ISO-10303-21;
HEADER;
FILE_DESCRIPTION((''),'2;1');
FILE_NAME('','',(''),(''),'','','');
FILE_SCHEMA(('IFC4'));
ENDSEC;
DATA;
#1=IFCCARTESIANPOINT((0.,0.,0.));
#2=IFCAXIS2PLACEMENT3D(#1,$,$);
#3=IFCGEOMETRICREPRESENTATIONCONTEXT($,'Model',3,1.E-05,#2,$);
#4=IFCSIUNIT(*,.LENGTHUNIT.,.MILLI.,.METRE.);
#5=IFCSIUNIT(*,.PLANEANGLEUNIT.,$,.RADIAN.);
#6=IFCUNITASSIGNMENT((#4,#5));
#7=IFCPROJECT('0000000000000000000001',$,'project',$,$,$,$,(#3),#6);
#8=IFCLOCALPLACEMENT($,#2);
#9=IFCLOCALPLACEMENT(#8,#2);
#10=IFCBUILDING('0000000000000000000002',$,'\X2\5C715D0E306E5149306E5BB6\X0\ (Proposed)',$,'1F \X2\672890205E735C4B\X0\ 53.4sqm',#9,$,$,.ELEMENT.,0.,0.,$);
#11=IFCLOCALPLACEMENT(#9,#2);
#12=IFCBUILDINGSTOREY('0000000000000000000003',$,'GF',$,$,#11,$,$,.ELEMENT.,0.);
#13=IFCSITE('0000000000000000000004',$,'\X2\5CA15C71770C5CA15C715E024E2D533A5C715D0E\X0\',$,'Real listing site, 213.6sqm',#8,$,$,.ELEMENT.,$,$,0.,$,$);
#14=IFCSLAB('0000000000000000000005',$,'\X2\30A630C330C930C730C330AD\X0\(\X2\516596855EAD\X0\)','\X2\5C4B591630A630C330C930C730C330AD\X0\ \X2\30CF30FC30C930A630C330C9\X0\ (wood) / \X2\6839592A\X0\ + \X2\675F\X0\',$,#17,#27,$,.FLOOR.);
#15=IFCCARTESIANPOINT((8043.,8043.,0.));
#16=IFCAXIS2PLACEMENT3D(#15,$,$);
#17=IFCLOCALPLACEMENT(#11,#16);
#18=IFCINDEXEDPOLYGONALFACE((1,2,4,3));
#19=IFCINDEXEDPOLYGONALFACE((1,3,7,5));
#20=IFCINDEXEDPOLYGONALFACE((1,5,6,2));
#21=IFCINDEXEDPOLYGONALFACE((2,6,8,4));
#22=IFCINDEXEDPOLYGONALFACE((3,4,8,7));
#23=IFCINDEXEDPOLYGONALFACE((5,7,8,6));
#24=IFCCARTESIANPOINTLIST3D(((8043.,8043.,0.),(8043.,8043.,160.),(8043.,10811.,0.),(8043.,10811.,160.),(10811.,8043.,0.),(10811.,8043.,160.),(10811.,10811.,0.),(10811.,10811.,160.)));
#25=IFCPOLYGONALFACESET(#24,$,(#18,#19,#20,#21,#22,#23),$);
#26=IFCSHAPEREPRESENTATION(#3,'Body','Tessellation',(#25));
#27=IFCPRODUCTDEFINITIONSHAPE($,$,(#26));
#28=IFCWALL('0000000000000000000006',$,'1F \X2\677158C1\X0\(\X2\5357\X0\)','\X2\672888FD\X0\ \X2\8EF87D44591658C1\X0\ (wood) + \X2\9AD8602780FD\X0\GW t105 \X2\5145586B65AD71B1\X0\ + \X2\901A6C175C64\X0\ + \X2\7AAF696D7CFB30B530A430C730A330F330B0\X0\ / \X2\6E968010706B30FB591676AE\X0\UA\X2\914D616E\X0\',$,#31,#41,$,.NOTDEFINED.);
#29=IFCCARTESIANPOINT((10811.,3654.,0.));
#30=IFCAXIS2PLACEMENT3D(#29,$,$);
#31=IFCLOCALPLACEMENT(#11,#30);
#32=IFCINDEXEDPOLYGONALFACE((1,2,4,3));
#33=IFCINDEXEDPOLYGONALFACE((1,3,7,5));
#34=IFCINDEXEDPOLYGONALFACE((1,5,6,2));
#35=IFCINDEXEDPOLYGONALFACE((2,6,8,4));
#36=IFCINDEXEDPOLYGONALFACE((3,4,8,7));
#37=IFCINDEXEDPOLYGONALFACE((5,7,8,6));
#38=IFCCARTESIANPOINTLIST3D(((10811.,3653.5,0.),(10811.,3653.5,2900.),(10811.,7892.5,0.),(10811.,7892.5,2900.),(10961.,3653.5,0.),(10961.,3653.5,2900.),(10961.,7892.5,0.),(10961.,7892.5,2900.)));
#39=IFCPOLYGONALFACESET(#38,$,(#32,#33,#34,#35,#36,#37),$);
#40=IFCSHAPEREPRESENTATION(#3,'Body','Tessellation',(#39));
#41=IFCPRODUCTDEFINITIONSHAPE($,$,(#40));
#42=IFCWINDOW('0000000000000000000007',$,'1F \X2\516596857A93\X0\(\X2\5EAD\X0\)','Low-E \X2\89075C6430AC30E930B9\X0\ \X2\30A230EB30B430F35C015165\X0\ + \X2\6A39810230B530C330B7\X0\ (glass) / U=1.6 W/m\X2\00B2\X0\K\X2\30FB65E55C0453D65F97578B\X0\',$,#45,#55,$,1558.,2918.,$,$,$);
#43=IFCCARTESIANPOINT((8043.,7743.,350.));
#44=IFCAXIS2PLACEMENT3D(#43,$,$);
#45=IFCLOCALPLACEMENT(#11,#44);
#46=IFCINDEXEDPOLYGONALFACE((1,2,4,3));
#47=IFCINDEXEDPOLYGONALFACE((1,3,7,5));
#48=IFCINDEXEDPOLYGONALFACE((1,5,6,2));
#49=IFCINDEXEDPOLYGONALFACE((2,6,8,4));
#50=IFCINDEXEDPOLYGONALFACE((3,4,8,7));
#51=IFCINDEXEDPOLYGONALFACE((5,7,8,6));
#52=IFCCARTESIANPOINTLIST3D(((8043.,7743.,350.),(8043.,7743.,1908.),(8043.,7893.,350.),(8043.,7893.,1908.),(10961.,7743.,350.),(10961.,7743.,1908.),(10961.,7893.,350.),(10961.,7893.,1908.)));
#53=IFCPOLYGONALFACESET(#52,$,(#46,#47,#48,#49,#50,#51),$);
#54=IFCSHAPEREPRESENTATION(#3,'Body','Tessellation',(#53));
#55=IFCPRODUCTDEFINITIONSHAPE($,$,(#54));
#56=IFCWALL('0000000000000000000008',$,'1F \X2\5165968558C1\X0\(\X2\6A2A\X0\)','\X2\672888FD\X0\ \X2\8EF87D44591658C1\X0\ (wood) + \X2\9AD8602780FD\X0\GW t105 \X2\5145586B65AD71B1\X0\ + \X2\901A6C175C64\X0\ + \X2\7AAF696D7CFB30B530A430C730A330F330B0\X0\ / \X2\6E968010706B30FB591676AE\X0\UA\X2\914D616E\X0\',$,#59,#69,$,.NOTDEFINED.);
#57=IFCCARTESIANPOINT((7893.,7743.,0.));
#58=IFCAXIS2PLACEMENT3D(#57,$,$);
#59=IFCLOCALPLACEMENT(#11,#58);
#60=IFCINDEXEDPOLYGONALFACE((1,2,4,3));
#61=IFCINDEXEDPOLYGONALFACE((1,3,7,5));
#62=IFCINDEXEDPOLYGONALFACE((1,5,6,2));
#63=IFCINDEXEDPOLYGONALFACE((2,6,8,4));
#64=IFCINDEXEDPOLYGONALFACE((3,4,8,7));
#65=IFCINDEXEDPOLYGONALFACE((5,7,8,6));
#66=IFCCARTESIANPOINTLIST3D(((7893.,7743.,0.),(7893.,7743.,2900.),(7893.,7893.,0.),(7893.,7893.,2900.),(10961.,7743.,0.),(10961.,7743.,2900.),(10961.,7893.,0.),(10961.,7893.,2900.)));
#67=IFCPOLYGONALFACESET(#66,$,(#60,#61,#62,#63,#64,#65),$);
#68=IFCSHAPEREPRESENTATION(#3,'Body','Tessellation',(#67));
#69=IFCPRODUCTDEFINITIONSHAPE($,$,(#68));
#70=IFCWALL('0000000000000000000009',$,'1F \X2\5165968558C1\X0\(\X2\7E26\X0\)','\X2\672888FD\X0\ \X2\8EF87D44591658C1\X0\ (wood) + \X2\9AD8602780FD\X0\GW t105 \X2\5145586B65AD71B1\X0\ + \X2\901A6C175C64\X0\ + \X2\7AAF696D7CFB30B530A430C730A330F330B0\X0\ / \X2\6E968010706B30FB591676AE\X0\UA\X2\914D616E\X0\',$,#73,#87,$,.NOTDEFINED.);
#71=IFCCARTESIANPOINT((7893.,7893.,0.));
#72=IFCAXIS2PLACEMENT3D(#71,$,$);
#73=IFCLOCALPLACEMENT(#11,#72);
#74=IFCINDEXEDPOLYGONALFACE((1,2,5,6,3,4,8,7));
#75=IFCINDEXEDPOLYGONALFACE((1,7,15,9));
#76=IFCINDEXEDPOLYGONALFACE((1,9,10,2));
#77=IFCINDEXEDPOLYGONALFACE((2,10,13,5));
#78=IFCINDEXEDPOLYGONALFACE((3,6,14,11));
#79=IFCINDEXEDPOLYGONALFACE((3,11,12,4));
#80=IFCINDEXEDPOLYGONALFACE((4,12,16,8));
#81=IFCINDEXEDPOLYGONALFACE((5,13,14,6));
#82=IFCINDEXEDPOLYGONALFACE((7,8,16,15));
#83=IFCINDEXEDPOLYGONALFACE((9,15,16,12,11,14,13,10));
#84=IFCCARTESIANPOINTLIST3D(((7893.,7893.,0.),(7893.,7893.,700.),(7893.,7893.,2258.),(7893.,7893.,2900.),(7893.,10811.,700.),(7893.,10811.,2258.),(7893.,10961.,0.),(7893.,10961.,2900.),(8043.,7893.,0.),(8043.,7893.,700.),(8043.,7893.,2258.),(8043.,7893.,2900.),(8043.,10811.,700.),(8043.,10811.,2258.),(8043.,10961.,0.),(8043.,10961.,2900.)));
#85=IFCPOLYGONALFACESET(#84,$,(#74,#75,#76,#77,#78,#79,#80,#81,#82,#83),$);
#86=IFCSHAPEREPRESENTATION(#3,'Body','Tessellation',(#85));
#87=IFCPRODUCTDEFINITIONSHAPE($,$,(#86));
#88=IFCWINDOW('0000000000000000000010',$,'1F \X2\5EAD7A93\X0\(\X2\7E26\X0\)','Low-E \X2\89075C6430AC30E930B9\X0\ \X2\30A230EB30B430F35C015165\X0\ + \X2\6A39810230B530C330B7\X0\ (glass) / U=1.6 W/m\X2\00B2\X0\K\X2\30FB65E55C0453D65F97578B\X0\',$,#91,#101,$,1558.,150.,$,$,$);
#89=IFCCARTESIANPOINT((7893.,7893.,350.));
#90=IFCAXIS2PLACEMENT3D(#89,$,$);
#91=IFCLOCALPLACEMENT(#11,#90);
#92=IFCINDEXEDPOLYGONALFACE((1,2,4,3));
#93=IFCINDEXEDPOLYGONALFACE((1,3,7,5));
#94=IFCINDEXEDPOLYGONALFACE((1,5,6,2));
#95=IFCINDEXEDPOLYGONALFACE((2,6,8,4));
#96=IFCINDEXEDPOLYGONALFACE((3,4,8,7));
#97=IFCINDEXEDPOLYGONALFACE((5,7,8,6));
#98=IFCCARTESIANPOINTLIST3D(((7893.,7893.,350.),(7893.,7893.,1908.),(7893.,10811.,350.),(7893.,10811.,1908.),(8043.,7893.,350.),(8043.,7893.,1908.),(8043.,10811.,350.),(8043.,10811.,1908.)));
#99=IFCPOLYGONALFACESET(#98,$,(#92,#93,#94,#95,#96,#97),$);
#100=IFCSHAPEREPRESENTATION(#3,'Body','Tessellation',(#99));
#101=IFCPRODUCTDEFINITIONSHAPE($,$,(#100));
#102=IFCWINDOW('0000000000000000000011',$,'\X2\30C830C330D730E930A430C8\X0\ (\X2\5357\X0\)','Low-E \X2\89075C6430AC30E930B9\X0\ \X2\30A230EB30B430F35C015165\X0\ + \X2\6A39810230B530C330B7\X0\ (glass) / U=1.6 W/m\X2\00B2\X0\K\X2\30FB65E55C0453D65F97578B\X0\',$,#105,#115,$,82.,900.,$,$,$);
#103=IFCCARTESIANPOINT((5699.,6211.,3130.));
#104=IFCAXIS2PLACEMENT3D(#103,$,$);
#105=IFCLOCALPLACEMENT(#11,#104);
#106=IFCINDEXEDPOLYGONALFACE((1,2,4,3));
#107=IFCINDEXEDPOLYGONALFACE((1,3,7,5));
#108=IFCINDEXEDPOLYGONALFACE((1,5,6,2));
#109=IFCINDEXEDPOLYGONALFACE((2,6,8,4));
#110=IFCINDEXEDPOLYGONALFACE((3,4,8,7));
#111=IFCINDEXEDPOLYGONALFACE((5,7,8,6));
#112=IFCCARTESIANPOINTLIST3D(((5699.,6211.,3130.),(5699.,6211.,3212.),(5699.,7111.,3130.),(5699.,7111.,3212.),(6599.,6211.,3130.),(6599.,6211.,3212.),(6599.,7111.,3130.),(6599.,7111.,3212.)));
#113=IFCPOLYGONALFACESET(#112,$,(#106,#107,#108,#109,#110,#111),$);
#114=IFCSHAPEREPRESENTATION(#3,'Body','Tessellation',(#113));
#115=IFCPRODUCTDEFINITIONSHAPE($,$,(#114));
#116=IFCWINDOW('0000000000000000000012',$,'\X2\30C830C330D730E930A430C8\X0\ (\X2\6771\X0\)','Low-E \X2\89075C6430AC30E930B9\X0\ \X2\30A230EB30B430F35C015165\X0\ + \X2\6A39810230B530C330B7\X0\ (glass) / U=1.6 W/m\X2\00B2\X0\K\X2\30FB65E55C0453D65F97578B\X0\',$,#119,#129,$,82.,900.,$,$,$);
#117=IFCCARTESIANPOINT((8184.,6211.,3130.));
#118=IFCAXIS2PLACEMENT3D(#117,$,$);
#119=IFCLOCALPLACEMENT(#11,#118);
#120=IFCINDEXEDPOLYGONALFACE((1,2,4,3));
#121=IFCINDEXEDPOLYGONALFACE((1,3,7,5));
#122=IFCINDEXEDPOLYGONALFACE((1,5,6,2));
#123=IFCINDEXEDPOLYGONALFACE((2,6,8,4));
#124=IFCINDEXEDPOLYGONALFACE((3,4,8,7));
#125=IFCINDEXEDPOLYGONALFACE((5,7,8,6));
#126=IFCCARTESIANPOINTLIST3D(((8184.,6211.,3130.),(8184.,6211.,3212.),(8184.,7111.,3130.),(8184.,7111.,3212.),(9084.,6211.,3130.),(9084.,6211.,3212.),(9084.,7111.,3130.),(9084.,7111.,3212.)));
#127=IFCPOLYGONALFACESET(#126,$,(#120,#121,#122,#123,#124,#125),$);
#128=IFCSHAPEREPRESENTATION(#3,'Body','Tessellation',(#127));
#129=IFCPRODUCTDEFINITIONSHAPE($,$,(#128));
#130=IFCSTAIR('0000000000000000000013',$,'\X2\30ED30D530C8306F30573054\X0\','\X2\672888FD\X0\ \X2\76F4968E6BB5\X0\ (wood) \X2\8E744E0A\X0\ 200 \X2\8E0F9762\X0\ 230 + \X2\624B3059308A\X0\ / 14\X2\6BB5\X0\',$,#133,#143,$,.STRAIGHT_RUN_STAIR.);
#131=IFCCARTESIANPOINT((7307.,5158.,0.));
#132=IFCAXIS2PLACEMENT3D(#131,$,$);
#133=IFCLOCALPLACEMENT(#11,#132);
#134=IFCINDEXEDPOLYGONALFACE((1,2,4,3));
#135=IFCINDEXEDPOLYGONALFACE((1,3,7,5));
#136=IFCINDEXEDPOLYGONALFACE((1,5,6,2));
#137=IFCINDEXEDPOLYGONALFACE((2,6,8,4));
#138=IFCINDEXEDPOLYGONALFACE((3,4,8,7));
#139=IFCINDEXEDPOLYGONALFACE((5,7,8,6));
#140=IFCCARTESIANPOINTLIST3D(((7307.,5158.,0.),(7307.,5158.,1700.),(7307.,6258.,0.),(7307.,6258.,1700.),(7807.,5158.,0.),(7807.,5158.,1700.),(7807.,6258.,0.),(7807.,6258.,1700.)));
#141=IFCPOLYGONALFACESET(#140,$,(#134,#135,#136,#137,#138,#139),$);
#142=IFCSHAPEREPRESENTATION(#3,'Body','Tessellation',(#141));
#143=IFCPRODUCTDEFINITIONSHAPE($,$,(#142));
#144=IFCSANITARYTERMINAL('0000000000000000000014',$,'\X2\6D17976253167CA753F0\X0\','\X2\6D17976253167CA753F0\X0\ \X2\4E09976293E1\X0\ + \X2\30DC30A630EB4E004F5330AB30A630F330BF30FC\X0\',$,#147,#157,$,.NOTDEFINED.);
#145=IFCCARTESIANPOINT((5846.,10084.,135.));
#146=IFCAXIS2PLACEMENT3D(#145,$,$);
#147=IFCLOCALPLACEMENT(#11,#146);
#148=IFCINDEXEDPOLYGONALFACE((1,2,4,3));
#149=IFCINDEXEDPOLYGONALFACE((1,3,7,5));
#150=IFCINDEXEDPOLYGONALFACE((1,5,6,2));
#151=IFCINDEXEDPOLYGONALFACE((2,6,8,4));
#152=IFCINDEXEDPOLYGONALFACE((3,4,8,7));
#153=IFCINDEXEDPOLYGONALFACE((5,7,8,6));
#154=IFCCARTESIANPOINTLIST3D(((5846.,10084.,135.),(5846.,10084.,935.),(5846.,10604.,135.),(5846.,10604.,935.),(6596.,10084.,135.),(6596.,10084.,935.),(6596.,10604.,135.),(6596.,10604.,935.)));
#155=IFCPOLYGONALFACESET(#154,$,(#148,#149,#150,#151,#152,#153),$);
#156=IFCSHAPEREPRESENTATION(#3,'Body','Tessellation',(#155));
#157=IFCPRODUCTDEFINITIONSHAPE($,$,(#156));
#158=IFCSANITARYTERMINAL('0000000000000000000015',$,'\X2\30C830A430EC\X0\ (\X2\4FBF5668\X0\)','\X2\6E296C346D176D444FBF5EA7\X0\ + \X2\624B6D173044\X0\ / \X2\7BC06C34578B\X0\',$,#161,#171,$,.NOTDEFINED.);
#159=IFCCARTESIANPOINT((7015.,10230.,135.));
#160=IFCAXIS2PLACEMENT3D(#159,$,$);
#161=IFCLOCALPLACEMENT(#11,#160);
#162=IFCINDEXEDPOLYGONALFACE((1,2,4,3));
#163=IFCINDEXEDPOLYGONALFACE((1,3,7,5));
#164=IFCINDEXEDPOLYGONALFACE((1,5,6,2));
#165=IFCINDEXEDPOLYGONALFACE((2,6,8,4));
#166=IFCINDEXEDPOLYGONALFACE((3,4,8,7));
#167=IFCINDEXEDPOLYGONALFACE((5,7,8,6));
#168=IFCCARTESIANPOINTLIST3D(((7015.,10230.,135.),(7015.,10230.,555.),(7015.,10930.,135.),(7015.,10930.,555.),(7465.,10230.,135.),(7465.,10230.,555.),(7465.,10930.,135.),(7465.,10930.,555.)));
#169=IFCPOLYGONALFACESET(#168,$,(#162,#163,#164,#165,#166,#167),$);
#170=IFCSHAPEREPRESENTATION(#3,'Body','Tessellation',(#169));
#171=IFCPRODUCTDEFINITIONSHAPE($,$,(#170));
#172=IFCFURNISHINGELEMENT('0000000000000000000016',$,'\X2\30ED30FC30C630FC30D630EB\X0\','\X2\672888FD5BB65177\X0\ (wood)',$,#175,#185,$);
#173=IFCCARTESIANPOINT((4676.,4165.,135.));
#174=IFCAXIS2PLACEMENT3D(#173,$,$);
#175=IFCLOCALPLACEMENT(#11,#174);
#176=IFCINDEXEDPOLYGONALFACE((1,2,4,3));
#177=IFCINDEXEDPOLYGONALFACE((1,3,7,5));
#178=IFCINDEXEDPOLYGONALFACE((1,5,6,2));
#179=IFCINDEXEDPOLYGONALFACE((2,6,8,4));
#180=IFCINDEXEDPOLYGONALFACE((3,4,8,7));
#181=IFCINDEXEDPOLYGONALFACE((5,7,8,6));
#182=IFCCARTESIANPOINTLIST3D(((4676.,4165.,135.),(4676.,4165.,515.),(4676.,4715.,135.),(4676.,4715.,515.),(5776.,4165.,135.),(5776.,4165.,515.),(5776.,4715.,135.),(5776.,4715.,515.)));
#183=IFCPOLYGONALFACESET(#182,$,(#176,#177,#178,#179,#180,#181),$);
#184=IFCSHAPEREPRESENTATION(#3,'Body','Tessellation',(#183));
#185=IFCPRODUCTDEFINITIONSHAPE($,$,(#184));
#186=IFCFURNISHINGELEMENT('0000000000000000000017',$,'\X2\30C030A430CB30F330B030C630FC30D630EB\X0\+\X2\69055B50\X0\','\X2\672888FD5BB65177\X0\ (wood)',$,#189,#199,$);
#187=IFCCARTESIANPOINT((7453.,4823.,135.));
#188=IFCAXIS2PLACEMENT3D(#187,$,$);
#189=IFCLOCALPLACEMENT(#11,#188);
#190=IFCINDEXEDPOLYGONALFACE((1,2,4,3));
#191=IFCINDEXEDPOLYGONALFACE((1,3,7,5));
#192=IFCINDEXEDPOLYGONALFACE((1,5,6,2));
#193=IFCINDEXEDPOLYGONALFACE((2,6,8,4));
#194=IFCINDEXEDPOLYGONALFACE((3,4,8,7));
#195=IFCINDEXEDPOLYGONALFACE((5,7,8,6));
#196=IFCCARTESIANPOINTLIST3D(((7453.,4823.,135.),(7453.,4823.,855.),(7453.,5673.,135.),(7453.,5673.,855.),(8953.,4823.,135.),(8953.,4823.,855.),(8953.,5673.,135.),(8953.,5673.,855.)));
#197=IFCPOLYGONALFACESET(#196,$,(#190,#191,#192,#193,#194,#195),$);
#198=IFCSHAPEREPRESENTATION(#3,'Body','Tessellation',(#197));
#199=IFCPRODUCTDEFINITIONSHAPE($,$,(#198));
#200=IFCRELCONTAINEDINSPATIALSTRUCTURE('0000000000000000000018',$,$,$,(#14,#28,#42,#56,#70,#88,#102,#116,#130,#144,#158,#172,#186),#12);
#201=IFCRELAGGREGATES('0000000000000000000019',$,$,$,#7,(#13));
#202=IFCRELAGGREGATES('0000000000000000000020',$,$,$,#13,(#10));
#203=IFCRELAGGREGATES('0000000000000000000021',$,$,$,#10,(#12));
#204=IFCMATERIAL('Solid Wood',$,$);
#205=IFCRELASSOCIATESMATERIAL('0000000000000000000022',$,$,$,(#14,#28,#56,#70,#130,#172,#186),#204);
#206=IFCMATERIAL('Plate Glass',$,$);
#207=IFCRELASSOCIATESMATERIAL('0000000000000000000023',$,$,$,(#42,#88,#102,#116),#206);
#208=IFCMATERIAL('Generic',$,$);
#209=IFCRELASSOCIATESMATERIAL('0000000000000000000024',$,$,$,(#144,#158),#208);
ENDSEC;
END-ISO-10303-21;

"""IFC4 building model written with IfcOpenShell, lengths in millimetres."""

from ifc_helpers import new_model, si_unit, frame, frame_2d, origin, place, context, project, spatial, rectangle, extrude, material, element, fill, save


model = new_model("IFC4")

# Units and contexts
model_context = context("Model", 3, precision=1e-05, world=origin())
ifc_project = project(units=[si_unit("LENGTHUNIT", "METRE", prefix="MILLI"), si_unit("PLANEANGLEUNIT", "RADIAN")], contexts=[model_context])

# Site, building, storey
site_placement = place(None, origin())
site = spatial("IfcSite", under=ifc_project, at=site_placement, Name="岡山県岡山市中区山崎", ObjectType="Real listing site, 213.6sqm", CompositionType="ELEMENT", RefElevation=0.0)
building_placement = place(site_placement, origin())
building = spatial("IfcBuilding", under=site, at=building_placement, Name="山崎の光の家 (Proposed)", ObjectType="1F 木造平屋 53.4sqm", CompositionType="ELEMENT", ElevationOfRefHeight=0.0, ElevationOfTerrain=0.0)
storey_placement = place(building_placement, origin())
storey = spatial("IfcBuildingStorey", under=building, at=storey_placement, Name="GF", CompositionType="ELEMENT", Elevation=0.0)

# Slab
ifc_material_1 = material(Name="Solid Wood")
slab_placement = place(storey_placement, frame((8043.0, 8043.0, 0.0)))
element("IfcSlab", 1, at=slab_placement, inside=storey, material=ifc_material_1, Name="ウッドデッキ(入隅庭)", Description="屋外ウッドデッキ ハードウッド (wood) / 根太 + 束", PredefinedType="FLOOR", context=model_context, shape_type="SweptSolid", body=[
    extrude(rectangle(XDim=2768.0, YDim=2768.0, at=frame_2d((1384.0, 1384.0))), frame((8043.0, 8043.0, 0.0)), (0.0, 0.0, 1.0), 160.0),
])

# Wall, opening, window
wall_1_placement = place(storey_placement, frame((10811.0, 3654.0, 0.0)))
wall_1 = element("IfcWall", 2, at=wall_1_placement, inside=storey, material=ifc_material_1, Name="1F 東壁(南)", Description="木製 軸組外壁 (wood) + 高性能GW t105 充填断熱 + 通気層 + 窯業系サイディング / 準耐火・外皮UA配慮", PredefinedType="NOTDEFINED", context=model_context, shape_type="SweptSolid", body=[
    extrude(rectangle(XDim=150.0, YDim=4239.0, at=frame_2d((75.0, 2119.0))), frame((10811.0, 3654.0, 0.0)), (0.0, 0.0, 1.0), 2900.0),
])
opening_1_placement = place(storey_placement, frame((8043.0, 7743.0, 350.0)))
opening_1 = element("IfcOpeningElement", 3, at=opening_1_placement, cuts=wall_1, PredefinedType="NOTDEFINED", context=model_context, shape_type="SweptSolid", body=[
    extrude(rectangle(XDim=2918.0, YDim=150.0, at=frame_2d((1459.0, 75.0))), frame((8043.0, 7743.0, 350.0)), (0.0, 0.0, 1.0), 1558.0),
])
ifc_material_2 = material(Name="Plate Glass")
window_1_placement = place(storey_placement, frame((8043.0, 7743.0, 350.0)))
window_1 = element("IfcWindow", 4, at=window_1_placement, inside=storey, material=ifc_material_2, Name="1F 入隅窓(庭)", Description="Low-E 複層ガラス アルゴン封入 + 樹脂サッシ (glass) / U=1.6 W/m²K・日射取得型", OverallHeight=1558.0, OverallWidth=2918.0, context=model_context, shape_type="SweptSolid", body=[
    extrude(rectangle(XDim=2918.0, YDim=150.0, at=frame_2d((1459.0, 75.0))), frame((8043.0, 7743.0, 350.0)), (0.0, 0.0, 1.0), 1558.0),
])
fill(opening_1, window_1)

# Wall
wall_2_placement = place(storey_placement, frame((7893.0, 7743.0, 0.0)))
element("IfcWall", 5, at=wall_2_placement, inside=storey, material=ifc_material_1, Name="1F 入隅壁(横)", Description="木製 軸組外壁 (wood) + 高性能GW t105 充填断熱 + 通気層 + 窯業系サイディング / 準耐火・外皮UA配慮", PredefinedType="NOTDEFINED", context=model_context, shape_type="SweptSolid", body=[
    extrude(rectangle(XDim=3068.0, YDim=150.0, at=frame_2d((1534.0, 75.0))), frame((7893.0, 7743.0, 0.0)), (0.0, 0.0, 1.0), 2900.0),
])

# Wall, opening, window
wall_3_placement = place(storey_placement, frame((7893.0, 7893.0, 0.0)))
wall_3 = element("IfcWall", 6, at=wall_3_placement, inside=storey, material=ifc_material_1, Name="1F 入隅壁(縦)", Description="木製 軸組外壁 (wood) + 高性能GW t105 充填断熱 + 通気層 + 窯業系サイディング / 準耐火・外皮UA配慮", PredefinedType="NOTDEFINED", context=model_context, shape_type="SweptSolid", body=[
    extrude(rectangle(XDim=150.0, YDim=3068.0, at=frame_2d((75.0, 1534.0))), frame((7893.0, 7893.0, 0.0)), (0.0, 0.0, 1.0), 2900.0),
])
opening_2_placement = place(storey_placement, frame((7893.0, 7893.0, 350.0)))
opening_2 = element("IfcOpeningElement", 7, at=opening_2_placement, cuts=wall_3, PredefinedType="NOTDEFINED", context=model_context, shape_type="SweptSolid", body=[
    extrude(rectangle(XDim=150.0, YDim=2918.0, at=frame_2d((75.0, 1459.0))), frame((7893.0, 7893.0, 350.0)), (0.0, 0.0, 1.0), 1558.0),
])
window_2_placement = place(storey_placement, frame((7893.0, 7893.0, 350.0)))
window_2 = element("IfcWindow", 8, at=window_2_placement, inside=storey, material=ifc_material_2, Name="1F 庭窓(縦)", Description="Low-E 複層ガラス アルゴン封入 + 樹脂サッシ (glass) / U=1.6 W/m²K・日射取得型", OverallHeight=1558.0, OverallWidth=150.0, context=model_context, shape_type="SweptSolid", body=[
    extrude(rectangle(XDim=150.0, YDim=2918.0, at=frame_2d((75.0, 1459.0))), frame((7893.0, 7893.0, 350.0)), (0.0, 0.0, 1.0), 1558.0),
])
fill(opening_2, window_2)

# Windows
window_3_placement = place(storey_placement, frame((5699.0, 6211.0, 3130.0)))
element("IfcWindow", 9, at=window_3_placement, inside=storey, material=ifc_material_2, Name="トップライト (南)", Description="Low-E 複層ガラス アルゴン封入 + 樹脂サッシ (glass) / U=1.6 W/m²K・日射取得型", OverallHeight=82.0, OverallWidth=900.0, context=model_context, shape_type="SweptSolid", body=[
    extrude(rectangle(XDim=900.0, YDim=900.0, at=frame_2d((450.0, 450.0))), frame((5699.0, 6211.0, 3130.0)), (0.0, 0.0, 1.0), 82.0),
])
window_4_placement = place(storey_placement, frame((8184.0, 6211.0, 3130.0)))
element("IfcWindow", 10, at=window_4_placement, inside=storey, material=ifc_material_2, Name="トップライト (東)", Description="Low-E 複層ガラス アルゴン封入 + 樹脂サッシ (glass) / U=1.6 W/m²K・日射取得型", OverallHeight=82.0, OverallWidth=900.0, context=model_context, shape_type="SweptSolid", body=[
    extrude(rectangle(XDim=900.0, YDim=900.0, at=frame_2d((450.0, 450.0))), frame((8184.0, 6211.0, 3130.0)), (0.0, 0.0, 1.0), 82.0),
])

# Stair
stair_placement = place(storey_placement, frame((7307.0, 5158.0, 0.0)))
element("IfcStair", 11, at=stair_placement, inside=storey, material=ifc_material_1, Name="ロフトはしご", Description="木製 直階段 (wood) 蹴上 200 踏面 230 + 手すり / 14段", PredefinedType="STRAIGHT_RUN_STAIR", context=model_context, shape_type="SweptSolid", body=[
    extrude(rectangle(XDim=500.0, YDim=1100.0, at=frame_2d((250.0, 550.0))), frame((7307.0, 5158.0, 0.0)), (0.0, 0.0, 1.0), 1700.0),
])

# Sanitary terminals
ifc_material_3 = material(Name="Generic")
sanitary_terminal_1_placement = place(storey_placement, frame((5846.0, 10084.0, 135.0)))
element("IfcSanitaryTerminal", 12, at=sanitary_terminal_1_placement, inside=storey, material=ifc_material_3, Name="洗面化粧台", Description="洗面化粧台 三面鏡 + ボウル一体カウンター", PredefinedType="NOTDEFINED", context=model_context, shape_type="SweptSolid", body=[
    extrude(rectangle(XDim=750.0, YDim=520.0, at=frame_2d((375.0, 260.0))), frame((5846.0, 10084.0, 135.0)), (0.0, 0.0, 1.0), 800.0),
])
sanitary_terminal_2_placement = place(storey_placement, frame((7015.0, 10230.0, 135.0)))
element("IfcSanitaryTerminal", 13, at=sanitary_terminal_2_placement, inside=storey, material=ifc_material_3, Name="トイレ (便器)", Description="温水洗浄便座 + 手洗い / 節水型", PredefinedType="NOTDEFINED", context=model_context, shape_type="SweptSolid", body=[
    extrude(rectangle(XDim=450.0, YDim=700.0, at=frame_2d((225.0, 350.0))), frame((7015.0, 10230.0, 135.0)), (0.0, 0.0, 1.0), 420.0),
])

# Furnishing elements
furnishing_1_placement = place(storey_placement, frame((4676.0, 4165.0, 135.0)))
element("IfcFurnishingElement", 14, at=furnishing_1_placement, inside=storey, material=ifc_material_1, Name="ローテーブル", Description="木製家具 (wood)", context=model_context, shape_type="SweptSolid", body=[
    extrude(rectangle(XDim=1100.0, YDim=550.0, at=frame_2d((550.0, 275.0))), frame((4676.0, 4165.0, 135.0)), (0.0, 0.0, 1.0), 380.0),
])
furnishing_2_placement = place(storey_placement, frame((7453.0, 4823.0, 135.0)))
element("IfcFurnishingElement", 15, at=furnishing_2_placement, inside=storey, material=ifc_material_1, Name="ダイニングテーブル+椅子", Description="木製家具 (wood)", context=model_context, shape_type="SweptSolid", body=[
    extrude(rectangle(XDim=1500.0, YDim=850.0, at=frame_2d((750.0, 425.0))), frame((7453.0, 4823.0, 135.0)), (0.0, 0.0, 1.0), 720.0),
])

save(model, "model.ifc")
